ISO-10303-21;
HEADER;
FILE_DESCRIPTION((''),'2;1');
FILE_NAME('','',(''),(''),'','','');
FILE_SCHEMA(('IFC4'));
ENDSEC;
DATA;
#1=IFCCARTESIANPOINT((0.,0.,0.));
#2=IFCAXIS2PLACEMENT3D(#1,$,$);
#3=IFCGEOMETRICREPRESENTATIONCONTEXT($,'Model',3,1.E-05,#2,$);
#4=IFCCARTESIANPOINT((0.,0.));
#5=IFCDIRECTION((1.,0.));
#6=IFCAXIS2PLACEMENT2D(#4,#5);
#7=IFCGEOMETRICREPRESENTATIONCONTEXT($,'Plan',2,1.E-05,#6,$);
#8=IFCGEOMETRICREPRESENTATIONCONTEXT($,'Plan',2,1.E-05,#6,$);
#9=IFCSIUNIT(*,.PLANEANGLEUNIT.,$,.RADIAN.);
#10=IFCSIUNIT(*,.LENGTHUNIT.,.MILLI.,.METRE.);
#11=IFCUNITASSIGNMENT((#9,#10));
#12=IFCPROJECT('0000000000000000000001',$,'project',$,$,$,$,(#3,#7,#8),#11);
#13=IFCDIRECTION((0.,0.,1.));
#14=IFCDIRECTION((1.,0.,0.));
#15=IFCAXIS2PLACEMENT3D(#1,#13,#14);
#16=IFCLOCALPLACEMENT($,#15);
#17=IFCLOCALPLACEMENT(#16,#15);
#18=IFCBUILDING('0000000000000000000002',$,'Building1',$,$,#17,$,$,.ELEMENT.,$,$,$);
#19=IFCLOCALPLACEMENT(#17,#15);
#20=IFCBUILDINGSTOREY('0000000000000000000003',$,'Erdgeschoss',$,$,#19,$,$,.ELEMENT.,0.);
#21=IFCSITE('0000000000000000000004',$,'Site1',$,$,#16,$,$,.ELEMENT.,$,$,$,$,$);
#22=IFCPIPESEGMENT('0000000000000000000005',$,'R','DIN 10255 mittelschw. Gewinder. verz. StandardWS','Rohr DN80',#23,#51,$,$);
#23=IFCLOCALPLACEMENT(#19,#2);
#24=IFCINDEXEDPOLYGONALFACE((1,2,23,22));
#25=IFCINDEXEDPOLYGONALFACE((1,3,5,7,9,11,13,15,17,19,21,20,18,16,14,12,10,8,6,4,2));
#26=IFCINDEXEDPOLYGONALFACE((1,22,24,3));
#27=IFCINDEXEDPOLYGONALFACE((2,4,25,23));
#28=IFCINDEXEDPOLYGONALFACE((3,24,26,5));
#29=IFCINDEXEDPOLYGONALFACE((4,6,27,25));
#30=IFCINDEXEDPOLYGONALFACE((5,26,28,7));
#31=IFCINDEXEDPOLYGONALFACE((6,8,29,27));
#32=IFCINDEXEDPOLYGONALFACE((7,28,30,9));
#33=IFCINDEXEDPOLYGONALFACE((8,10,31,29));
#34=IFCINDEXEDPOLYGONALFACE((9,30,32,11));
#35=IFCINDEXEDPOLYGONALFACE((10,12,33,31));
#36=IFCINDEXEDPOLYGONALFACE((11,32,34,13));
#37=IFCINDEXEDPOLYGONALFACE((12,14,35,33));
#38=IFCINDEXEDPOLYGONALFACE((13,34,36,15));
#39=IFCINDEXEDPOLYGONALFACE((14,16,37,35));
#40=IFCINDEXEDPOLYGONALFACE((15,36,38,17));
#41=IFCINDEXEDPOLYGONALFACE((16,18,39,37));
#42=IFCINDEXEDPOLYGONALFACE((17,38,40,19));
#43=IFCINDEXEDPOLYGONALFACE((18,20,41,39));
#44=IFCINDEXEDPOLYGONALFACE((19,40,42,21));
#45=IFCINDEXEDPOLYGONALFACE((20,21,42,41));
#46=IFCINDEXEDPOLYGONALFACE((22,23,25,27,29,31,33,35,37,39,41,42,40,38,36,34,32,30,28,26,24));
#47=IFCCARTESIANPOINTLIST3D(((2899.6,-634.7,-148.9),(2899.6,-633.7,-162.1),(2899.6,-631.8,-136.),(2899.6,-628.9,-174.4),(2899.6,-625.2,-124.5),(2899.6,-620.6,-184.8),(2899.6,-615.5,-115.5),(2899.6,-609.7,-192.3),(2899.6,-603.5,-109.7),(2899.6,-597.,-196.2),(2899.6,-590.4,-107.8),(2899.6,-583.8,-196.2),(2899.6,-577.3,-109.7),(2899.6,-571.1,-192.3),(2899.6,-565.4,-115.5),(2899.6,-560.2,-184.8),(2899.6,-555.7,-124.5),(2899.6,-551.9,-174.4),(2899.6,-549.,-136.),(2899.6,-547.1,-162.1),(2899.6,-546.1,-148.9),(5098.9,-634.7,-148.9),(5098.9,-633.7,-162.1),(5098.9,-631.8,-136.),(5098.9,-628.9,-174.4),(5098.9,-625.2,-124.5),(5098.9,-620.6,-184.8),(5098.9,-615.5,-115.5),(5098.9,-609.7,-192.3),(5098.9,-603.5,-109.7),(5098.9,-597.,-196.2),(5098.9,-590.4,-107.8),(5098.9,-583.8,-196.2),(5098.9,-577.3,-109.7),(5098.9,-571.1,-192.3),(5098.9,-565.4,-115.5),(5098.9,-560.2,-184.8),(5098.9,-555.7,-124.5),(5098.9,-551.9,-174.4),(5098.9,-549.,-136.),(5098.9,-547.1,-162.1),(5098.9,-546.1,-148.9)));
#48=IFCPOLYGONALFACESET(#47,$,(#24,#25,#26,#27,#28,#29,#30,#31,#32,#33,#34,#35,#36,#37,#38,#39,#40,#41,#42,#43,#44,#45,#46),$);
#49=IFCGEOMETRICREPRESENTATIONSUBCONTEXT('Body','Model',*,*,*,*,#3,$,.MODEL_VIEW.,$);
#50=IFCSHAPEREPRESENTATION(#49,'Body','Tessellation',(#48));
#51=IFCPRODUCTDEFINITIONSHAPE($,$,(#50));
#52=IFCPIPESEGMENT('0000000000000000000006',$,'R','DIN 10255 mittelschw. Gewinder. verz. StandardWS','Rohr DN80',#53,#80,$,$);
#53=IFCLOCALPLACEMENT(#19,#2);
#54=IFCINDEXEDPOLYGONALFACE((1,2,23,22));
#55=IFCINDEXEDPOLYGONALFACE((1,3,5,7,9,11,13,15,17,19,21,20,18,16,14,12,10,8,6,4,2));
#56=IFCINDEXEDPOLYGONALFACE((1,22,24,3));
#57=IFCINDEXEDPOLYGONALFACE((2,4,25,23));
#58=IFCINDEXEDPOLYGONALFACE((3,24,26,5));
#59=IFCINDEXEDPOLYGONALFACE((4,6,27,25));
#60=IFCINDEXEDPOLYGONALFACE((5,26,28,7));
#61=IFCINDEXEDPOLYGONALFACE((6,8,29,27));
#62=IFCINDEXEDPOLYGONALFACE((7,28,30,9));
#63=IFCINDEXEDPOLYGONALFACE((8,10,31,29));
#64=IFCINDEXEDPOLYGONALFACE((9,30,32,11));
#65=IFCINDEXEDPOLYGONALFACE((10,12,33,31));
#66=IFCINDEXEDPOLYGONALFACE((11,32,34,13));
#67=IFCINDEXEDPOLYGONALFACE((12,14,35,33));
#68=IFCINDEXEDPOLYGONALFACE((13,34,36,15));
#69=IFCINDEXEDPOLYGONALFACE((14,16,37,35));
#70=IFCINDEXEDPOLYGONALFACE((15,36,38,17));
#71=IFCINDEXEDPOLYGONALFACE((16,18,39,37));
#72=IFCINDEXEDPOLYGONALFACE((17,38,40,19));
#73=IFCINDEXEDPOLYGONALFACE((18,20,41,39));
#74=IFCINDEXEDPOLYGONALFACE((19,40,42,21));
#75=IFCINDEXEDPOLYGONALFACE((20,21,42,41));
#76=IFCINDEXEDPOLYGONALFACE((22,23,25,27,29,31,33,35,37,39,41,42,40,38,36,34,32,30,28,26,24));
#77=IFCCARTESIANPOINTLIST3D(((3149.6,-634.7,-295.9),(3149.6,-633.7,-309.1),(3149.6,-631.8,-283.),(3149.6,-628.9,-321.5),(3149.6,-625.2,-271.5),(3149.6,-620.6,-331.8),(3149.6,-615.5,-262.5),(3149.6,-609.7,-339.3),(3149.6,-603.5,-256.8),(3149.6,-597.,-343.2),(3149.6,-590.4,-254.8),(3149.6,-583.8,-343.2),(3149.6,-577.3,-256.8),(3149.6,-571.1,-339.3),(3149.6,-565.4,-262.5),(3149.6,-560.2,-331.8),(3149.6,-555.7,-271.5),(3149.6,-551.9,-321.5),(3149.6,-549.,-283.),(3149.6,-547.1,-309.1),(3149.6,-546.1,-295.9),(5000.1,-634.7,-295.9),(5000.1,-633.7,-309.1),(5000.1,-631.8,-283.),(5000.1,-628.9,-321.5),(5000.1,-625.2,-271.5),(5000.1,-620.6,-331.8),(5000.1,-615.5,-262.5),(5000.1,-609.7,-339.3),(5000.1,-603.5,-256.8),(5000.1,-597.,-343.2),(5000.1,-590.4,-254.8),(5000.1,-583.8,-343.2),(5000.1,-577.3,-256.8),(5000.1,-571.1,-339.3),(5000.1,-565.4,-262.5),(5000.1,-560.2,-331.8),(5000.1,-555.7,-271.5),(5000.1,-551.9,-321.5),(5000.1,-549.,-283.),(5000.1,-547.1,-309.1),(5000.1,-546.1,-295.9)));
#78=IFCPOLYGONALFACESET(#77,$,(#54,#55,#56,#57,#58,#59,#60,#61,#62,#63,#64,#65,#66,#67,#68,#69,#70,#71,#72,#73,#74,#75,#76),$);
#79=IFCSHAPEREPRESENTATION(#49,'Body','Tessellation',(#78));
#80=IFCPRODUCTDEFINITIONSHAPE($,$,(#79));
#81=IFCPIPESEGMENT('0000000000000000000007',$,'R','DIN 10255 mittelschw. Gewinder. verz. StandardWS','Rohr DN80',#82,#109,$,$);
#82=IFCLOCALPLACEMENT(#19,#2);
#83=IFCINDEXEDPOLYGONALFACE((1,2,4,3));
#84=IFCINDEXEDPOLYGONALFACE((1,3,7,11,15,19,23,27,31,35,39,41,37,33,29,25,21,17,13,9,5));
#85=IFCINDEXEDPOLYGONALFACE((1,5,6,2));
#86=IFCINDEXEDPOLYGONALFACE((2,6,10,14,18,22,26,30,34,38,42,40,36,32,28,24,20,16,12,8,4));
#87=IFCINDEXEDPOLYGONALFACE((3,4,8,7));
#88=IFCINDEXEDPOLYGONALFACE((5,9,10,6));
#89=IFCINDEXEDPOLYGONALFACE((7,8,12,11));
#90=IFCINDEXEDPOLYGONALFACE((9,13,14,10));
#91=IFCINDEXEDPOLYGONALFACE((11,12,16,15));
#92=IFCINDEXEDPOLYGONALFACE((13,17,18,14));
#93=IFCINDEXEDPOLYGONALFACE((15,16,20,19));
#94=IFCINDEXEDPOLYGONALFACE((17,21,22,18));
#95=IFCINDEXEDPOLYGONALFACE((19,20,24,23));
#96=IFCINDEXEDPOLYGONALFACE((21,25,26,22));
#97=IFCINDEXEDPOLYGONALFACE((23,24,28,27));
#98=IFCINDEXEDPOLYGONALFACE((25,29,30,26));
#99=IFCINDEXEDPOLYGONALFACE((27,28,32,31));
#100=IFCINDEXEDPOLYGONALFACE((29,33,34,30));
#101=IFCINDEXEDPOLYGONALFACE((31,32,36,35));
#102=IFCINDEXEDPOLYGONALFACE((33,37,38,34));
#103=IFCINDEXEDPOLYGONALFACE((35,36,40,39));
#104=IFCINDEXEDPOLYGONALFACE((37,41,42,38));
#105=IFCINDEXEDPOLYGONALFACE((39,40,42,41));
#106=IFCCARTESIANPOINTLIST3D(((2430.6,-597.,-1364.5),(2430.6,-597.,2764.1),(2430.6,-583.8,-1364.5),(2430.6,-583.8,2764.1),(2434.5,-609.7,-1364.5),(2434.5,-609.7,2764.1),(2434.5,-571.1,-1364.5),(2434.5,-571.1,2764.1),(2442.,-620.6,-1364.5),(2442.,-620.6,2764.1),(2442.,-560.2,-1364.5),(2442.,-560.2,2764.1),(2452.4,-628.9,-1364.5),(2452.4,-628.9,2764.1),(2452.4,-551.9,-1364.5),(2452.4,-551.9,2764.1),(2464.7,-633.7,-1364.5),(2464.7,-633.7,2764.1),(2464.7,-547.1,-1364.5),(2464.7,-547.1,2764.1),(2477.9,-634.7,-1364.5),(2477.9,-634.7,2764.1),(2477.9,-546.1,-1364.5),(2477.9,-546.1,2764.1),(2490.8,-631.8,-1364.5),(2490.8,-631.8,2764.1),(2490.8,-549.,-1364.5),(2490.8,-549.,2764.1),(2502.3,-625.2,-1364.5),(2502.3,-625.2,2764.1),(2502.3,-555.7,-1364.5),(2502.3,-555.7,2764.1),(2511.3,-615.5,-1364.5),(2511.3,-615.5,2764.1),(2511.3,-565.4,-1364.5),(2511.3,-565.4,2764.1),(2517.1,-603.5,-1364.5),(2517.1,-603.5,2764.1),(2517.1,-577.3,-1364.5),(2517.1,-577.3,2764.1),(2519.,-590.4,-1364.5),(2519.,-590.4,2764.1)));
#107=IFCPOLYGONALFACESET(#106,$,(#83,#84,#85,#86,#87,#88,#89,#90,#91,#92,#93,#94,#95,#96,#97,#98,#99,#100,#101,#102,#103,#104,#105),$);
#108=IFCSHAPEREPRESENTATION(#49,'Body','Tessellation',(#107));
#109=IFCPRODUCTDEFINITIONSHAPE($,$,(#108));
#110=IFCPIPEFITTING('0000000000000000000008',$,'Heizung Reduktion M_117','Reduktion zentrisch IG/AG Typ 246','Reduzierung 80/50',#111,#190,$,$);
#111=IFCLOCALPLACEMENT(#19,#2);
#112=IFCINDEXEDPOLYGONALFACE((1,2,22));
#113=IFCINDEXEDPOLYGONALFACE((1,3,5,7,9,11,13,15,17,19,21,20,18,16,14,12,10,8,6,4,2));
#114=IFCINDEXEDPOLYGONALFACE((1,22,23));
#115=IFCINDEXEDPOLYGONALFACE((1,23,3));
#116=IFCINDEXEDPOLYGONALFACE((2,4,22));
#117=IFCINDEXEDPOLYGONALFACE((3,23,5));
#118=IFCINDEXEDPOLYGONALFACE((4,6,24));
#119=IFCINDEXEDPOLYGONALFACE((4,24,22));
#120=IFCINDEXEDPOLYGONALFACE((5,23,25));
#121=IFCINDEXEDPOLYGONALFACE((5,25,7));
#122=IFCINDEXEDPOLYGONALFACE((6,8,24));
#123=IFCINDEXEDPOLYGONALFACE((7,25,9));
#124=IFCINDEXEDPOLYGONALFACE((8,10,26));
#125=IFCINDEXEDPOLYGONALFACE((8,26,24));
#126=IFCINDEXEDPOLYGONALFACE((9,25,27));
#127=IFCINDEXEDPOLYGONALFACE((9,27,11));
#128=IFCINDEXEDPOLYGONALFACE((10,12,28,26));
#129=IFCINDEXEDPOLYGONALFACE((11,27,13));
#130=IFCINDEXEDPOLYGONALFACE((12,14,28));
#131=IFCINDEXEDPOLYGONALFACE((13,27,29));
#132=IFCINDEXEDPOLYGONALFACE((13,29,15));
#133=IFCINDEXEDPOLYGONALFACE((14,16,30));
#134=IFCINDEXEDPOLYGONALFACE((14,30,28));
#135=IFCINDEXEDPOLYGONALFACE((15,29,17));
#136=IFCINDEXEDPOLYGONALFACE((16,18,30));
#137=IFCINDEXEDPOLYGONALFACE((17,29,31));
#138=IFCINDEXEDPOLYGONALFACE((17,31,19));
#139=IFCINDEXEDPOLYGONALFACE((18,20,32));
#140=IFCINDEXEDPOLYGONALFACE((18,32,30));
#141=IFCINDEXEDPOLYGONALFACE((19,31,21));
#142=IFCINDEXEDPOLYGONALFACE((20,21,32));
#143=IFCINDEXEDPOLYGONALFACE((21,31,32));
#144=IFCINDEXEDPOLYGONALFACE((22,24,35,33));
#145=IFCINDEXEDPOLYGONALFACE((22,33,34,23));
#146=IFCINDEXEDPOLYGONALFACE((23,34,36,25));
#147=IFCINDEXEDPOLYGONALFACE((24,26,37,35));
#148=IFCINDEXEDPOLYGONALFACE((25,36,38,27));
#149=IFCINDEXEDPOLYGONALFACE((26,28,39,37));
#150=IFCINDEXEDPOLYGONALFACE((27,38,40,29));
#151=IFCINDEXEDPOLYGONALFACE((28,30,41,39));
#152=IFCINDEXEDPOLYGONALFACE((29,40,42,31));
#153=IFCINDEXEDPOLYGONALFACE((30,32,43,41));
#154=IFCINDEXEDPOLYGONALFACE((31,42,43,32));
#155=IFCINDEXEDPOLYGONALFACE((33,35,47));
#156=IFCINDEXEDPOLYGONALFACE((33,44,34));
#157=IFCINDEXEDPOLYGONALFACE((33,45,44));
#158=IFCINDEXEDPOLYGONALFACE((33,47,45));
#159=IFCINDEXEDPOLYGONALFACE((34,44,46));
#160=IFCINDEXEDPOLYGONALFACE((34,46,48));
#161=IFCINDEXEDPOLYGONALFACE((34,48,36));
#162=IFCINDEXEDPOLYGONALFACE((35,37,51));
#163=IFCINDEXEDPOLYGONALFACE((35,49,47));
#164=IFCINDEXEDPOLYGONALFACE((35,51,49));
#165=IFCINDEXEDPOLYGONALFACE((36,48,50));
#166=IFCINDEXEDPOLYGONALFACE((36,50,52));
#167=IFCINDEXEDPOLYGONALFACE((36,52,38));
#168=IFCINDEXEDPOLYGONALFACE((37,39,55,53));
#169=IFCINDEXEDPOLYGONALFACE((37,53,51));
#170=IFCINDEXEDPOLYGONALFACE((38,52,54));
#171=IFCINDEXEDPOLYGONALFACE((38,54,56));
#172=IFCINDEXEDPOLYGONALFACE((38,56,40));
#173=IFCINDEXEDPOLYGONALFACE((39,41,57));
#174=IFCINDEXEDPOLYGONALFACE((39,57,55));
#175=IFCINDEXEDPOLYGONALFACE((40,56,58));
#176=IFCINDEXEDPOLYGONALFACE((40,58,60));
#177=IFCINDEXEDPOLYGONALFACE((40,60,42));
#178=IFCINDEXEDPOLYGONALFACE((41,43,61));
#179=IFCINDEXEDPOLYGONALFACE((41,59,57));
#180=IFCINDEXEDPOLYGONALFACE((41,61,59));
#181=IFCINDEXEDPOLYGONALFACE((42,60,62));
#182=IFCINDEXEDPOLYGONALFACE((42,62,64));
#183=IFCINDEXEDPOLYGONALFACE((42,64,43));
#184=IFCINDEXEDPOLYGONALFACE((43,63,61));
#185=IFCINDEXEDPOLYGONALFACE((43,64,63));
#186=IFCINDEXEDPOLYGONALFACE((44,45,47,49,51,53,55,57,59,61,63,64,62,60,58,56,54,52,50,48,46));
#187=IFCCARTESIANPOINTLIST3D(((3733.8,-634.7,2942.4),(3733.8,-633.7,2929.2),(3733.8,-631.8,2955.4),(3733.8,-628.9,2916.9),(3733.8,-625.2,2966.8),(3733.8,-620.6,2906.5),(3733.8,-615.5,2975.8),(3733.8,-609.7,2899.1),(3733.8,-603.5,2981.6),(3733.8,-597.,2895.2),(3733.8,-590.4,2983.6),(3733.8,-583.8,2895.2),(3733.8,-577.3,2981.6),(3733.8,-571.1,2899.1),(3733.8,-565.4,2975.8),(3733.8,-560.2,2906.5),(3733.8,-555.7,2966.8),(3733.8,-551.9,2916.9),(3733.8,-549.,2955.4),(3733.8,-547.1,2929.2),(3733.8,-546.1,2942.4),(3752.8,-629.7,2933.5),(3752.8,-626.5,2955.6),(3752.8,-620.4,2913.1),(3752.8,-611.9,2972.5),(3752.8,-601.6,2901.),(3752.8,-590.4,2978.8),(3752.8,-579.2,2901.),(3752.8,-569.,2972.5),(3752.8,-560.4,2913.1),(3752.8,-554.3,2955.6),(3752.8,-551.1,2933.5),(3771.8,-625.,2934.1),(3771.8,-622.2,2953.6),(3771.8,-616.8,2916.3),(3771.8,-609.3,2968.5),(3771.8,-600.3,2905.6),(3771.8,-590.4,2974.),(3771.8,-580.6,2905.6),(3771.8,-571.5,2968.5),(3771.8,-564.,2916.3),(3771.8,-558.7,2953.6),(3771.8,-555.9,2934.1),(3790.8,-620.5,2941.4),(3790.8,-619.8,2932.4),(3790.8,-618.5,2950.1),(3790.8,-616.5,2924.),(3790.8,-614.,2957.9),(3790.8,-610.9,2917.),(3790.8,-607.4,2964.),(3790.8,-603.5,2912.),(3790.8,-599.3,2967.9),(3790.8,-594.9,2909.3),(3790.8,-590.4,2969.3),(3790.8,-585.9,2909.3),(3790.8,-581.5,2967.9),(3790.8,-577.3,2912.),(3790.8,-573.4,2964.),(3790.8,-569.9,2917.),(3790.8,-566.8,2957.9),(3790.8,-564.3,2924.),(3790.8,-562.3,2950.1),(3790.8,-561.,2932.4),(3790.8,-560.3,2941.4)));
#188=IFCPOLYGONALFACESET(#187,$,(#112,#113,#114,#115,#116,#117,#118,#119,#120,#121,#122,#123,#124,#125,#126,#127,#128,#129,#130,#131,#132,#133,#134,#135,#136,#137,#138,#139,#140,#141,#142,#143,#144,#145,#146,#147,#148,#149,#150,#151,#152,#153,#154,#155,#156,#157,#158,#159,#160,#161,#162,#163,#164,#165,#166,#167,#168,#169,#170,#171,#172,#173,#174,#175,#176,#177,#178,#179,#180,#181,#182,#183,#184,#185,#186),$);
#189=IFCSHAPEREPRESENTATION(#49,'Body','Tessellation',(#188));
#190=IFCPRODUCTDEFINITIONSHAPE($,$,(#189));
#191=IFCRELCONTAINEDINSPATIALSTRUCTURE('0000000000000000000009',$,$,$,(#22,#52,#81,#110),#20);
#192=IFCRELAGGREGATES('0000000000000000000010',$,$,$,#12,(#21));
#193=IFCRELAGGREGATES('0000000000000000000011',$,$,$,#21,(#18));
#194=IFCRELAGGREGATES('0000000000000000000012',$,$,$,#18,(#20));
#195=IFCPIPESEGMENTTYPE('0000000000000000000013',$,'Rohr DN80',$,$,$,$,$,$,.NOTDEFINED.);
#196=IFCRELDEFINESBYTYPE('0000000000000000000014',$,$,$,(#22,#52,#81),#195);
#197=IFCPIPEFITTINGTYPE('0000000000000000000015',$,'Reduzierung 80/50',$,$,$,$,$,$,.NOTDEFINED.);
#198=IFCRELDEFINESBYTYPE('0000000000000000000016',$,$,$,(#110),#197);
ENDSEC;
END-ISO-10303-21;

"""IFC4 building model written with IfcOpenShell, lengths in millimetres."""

from ifc_helpers import new_model, entity, si_unit, frame, origin, origin_with_axes, origin_2d_with_axis, place, context, subcontext, project, spatial, circle, extrude, source, transform, mapped, type_object, element, save


model = new_model("IFC4")

# Units and contexts
model_context = context("Model", 3, precision=1e-05, world=origin())
plan_context_1 = context("Plan", 2, precision=1e-05, world=origin_2d_with_axis())
plan_context_2 = context("Plan", 2, precision=1e-05, world=origin_2d_with_axis())
body_context = subcontext(model_context, "Body", "Model", "MODEL_VIEW")
ifc_project = project(units=[si_unit("PLANEANGLEUNIT", "RADIAN"), si_unit("LENGTHUNIT", "METRE", prefix="MILLI")], contexts=[model_context, plan_context_1, plan_context_2])

# Site, building, storey
site_placement = place(None, origin_with_axes())
site = spatial("IfcSite", under=ifc_project, at=site_placement, Name="Site1", CompositionType="ELEMENT")
building_placement = place(site_placement, origin_with_axes())
building = spatial("IfcBuilding", under=site, at=building_placement, Name="Building1", CompositionType="ELEMENT")
storey_placement = place(building_placement, origin_with_axes())
storey = spatial("IfcBuildingStorey", under=building, at=storey_placement, Name="Erdgeschoss", CompositionType="ELEMENT", Elevation=0.0)

# Pipe segments
pipe_segment_type_1 = type_object("IfcPipeSegmentType", Name="Rohr DN80", PredefinedType="NOTDEFINED")
pipe_segment_1_placement = place(storey_placement, frame((3999.2, -590.3, -152.2), z_axis=(0.0, 0.0, 1.0), x_axis=(1.0, 0.0, 0.0)))
element("IfcPipeSegment", 1, at=pipe_segment_1_placement, inside=storey, type_object=pipe_segment_type_1, Name="R", Description="DIN 10255 mittelschw. Gewinder. verz. StandardWS", ObjectType="Rohr DN80", context=body_context, shape_type="SolidModel", body=[
    extrude(circle(Radius=44.5, at=origin_2d_with_axis()), frame((-1099.6, -0.2, 0.0), z_axis=(1.0, 0.0, 0.0), x_axis=(0.0, 0.0, 1.0)), (0.0, 0.0, 1.0), 2199.3),
])
pipe_segment_2_placement = place(storey_placement, frame((4074.8, -590.3, -299.2), z_axis=(0.0, 0.0, 1.0), x_axis=(1.0, 0.0, 0.0)))
element("IfcPipeSegment", 2, at=pipe_segment_2_placement, inside=storey, type_object=pipe_segment_type_1, Name="R", Description="DIN 10255 mittelschw. Gewinder. verz. StandardWS", ObjectType="Rohr DN80", context=body_context, shape_type="SolidModel", body=[
    extrude(circle(Radius=44.5, at=origin_2d_with_axis()), frame((-925.3, -0.2, 0.0), z_axis=(1.0, 0.0, 0.0), x_axis=(0.0, 0.0, 1.0)), (0.0, 0.0, 1.0), 1850.5),
])
pipe_segment_3_placement = place(storey_placement, frame((2474.6, -590.6, 699.8), z_axis=(0.0, 0.0, 1.0), x_axis=(1.0, 0.0, 0.0)))
element("IfcPipeSegment", 3, at=pipe_segment_3_placement, inside=storey, type_object=pipe_segment_type_1, Name="R", Description="DIN 10255 mittelschw. Gewinder. verz. StandardWS", ObjectType="Rohr DN80", context=body_context, shape_type="SolidModel", body=[
    extrude(circle(Radius=44.5, at=origin_2d_with_axis()), frame((0.0, 0.1, -2064.3), z_axis=(0.0, 0.0, 1.0), x_axis=(1.0, 0.0, 0.0)), (0.0, 0.0, 1.0), 4128.7),
])

# Pipe fitting
pipe_fitting_type_1 = type_object("IfcPipeFittingType", Name="Reduzierung 80/50", PredefinedType="NOTDEFINED")
axis2_placement2_d = entity("IfcAxis2Placement2D", entity("IfcCartesianPoint", [0.0, 0.0]), entity("IfcDirection", [1.0, 0.0]))
shared_shape_1 = source(origin_with_axes(), body_context, "Body", "SolidModel", [
    entity("IfcExtrudedAreaSolidTapered", entity("IfcCircleProfileDef", "AREA", None, axis2_placement2_d, 44.5), entity("IfcAxis2Placement3D", entity("IfcCartesianPoint", [-28.5, -0.1, 0.0]), entity("IfcDirection", [1.0, 0.0, 0.0]), entity("IfcDirection", [0.0, 0.0, 1.0])), entity("IfcDirection", [0.0, 0.0, 1.0]), 57.0, entity("IfcCircleProfileDef", "AREA", None, axis2_placement2_d, 30.1)),
])
pipe_fitting_1_placement = place(storey_placement, frame((3762.3, -590.3, 2939.1), z_axis=(0.0, 0.0, 1.0), x_axis=(1.0, 0.0, 0.0)))
element("IfcPipeFitting", 4, at=pipe_fitting_1_placement, inside=storey, type_object=pipe_fitting_type_1, Name="Heizung Reduktion M_117", Description="Reduktion zentrisch IG/AG Typ 246", ObjectType="Reduzierung 80/50", context=body_context, shape_type="MappedRepresentation", body=[
    mapped(shared_shape_1, transform((0.0, 0.0, 0.0), x_axis=(1.0, 0.0, 0.0), y_axis=(0.0, 1.0, 0.0), z_axis=(0.0, 0.0, 1.0), scale=1.0)),
])

save(model, "model.ifc")
